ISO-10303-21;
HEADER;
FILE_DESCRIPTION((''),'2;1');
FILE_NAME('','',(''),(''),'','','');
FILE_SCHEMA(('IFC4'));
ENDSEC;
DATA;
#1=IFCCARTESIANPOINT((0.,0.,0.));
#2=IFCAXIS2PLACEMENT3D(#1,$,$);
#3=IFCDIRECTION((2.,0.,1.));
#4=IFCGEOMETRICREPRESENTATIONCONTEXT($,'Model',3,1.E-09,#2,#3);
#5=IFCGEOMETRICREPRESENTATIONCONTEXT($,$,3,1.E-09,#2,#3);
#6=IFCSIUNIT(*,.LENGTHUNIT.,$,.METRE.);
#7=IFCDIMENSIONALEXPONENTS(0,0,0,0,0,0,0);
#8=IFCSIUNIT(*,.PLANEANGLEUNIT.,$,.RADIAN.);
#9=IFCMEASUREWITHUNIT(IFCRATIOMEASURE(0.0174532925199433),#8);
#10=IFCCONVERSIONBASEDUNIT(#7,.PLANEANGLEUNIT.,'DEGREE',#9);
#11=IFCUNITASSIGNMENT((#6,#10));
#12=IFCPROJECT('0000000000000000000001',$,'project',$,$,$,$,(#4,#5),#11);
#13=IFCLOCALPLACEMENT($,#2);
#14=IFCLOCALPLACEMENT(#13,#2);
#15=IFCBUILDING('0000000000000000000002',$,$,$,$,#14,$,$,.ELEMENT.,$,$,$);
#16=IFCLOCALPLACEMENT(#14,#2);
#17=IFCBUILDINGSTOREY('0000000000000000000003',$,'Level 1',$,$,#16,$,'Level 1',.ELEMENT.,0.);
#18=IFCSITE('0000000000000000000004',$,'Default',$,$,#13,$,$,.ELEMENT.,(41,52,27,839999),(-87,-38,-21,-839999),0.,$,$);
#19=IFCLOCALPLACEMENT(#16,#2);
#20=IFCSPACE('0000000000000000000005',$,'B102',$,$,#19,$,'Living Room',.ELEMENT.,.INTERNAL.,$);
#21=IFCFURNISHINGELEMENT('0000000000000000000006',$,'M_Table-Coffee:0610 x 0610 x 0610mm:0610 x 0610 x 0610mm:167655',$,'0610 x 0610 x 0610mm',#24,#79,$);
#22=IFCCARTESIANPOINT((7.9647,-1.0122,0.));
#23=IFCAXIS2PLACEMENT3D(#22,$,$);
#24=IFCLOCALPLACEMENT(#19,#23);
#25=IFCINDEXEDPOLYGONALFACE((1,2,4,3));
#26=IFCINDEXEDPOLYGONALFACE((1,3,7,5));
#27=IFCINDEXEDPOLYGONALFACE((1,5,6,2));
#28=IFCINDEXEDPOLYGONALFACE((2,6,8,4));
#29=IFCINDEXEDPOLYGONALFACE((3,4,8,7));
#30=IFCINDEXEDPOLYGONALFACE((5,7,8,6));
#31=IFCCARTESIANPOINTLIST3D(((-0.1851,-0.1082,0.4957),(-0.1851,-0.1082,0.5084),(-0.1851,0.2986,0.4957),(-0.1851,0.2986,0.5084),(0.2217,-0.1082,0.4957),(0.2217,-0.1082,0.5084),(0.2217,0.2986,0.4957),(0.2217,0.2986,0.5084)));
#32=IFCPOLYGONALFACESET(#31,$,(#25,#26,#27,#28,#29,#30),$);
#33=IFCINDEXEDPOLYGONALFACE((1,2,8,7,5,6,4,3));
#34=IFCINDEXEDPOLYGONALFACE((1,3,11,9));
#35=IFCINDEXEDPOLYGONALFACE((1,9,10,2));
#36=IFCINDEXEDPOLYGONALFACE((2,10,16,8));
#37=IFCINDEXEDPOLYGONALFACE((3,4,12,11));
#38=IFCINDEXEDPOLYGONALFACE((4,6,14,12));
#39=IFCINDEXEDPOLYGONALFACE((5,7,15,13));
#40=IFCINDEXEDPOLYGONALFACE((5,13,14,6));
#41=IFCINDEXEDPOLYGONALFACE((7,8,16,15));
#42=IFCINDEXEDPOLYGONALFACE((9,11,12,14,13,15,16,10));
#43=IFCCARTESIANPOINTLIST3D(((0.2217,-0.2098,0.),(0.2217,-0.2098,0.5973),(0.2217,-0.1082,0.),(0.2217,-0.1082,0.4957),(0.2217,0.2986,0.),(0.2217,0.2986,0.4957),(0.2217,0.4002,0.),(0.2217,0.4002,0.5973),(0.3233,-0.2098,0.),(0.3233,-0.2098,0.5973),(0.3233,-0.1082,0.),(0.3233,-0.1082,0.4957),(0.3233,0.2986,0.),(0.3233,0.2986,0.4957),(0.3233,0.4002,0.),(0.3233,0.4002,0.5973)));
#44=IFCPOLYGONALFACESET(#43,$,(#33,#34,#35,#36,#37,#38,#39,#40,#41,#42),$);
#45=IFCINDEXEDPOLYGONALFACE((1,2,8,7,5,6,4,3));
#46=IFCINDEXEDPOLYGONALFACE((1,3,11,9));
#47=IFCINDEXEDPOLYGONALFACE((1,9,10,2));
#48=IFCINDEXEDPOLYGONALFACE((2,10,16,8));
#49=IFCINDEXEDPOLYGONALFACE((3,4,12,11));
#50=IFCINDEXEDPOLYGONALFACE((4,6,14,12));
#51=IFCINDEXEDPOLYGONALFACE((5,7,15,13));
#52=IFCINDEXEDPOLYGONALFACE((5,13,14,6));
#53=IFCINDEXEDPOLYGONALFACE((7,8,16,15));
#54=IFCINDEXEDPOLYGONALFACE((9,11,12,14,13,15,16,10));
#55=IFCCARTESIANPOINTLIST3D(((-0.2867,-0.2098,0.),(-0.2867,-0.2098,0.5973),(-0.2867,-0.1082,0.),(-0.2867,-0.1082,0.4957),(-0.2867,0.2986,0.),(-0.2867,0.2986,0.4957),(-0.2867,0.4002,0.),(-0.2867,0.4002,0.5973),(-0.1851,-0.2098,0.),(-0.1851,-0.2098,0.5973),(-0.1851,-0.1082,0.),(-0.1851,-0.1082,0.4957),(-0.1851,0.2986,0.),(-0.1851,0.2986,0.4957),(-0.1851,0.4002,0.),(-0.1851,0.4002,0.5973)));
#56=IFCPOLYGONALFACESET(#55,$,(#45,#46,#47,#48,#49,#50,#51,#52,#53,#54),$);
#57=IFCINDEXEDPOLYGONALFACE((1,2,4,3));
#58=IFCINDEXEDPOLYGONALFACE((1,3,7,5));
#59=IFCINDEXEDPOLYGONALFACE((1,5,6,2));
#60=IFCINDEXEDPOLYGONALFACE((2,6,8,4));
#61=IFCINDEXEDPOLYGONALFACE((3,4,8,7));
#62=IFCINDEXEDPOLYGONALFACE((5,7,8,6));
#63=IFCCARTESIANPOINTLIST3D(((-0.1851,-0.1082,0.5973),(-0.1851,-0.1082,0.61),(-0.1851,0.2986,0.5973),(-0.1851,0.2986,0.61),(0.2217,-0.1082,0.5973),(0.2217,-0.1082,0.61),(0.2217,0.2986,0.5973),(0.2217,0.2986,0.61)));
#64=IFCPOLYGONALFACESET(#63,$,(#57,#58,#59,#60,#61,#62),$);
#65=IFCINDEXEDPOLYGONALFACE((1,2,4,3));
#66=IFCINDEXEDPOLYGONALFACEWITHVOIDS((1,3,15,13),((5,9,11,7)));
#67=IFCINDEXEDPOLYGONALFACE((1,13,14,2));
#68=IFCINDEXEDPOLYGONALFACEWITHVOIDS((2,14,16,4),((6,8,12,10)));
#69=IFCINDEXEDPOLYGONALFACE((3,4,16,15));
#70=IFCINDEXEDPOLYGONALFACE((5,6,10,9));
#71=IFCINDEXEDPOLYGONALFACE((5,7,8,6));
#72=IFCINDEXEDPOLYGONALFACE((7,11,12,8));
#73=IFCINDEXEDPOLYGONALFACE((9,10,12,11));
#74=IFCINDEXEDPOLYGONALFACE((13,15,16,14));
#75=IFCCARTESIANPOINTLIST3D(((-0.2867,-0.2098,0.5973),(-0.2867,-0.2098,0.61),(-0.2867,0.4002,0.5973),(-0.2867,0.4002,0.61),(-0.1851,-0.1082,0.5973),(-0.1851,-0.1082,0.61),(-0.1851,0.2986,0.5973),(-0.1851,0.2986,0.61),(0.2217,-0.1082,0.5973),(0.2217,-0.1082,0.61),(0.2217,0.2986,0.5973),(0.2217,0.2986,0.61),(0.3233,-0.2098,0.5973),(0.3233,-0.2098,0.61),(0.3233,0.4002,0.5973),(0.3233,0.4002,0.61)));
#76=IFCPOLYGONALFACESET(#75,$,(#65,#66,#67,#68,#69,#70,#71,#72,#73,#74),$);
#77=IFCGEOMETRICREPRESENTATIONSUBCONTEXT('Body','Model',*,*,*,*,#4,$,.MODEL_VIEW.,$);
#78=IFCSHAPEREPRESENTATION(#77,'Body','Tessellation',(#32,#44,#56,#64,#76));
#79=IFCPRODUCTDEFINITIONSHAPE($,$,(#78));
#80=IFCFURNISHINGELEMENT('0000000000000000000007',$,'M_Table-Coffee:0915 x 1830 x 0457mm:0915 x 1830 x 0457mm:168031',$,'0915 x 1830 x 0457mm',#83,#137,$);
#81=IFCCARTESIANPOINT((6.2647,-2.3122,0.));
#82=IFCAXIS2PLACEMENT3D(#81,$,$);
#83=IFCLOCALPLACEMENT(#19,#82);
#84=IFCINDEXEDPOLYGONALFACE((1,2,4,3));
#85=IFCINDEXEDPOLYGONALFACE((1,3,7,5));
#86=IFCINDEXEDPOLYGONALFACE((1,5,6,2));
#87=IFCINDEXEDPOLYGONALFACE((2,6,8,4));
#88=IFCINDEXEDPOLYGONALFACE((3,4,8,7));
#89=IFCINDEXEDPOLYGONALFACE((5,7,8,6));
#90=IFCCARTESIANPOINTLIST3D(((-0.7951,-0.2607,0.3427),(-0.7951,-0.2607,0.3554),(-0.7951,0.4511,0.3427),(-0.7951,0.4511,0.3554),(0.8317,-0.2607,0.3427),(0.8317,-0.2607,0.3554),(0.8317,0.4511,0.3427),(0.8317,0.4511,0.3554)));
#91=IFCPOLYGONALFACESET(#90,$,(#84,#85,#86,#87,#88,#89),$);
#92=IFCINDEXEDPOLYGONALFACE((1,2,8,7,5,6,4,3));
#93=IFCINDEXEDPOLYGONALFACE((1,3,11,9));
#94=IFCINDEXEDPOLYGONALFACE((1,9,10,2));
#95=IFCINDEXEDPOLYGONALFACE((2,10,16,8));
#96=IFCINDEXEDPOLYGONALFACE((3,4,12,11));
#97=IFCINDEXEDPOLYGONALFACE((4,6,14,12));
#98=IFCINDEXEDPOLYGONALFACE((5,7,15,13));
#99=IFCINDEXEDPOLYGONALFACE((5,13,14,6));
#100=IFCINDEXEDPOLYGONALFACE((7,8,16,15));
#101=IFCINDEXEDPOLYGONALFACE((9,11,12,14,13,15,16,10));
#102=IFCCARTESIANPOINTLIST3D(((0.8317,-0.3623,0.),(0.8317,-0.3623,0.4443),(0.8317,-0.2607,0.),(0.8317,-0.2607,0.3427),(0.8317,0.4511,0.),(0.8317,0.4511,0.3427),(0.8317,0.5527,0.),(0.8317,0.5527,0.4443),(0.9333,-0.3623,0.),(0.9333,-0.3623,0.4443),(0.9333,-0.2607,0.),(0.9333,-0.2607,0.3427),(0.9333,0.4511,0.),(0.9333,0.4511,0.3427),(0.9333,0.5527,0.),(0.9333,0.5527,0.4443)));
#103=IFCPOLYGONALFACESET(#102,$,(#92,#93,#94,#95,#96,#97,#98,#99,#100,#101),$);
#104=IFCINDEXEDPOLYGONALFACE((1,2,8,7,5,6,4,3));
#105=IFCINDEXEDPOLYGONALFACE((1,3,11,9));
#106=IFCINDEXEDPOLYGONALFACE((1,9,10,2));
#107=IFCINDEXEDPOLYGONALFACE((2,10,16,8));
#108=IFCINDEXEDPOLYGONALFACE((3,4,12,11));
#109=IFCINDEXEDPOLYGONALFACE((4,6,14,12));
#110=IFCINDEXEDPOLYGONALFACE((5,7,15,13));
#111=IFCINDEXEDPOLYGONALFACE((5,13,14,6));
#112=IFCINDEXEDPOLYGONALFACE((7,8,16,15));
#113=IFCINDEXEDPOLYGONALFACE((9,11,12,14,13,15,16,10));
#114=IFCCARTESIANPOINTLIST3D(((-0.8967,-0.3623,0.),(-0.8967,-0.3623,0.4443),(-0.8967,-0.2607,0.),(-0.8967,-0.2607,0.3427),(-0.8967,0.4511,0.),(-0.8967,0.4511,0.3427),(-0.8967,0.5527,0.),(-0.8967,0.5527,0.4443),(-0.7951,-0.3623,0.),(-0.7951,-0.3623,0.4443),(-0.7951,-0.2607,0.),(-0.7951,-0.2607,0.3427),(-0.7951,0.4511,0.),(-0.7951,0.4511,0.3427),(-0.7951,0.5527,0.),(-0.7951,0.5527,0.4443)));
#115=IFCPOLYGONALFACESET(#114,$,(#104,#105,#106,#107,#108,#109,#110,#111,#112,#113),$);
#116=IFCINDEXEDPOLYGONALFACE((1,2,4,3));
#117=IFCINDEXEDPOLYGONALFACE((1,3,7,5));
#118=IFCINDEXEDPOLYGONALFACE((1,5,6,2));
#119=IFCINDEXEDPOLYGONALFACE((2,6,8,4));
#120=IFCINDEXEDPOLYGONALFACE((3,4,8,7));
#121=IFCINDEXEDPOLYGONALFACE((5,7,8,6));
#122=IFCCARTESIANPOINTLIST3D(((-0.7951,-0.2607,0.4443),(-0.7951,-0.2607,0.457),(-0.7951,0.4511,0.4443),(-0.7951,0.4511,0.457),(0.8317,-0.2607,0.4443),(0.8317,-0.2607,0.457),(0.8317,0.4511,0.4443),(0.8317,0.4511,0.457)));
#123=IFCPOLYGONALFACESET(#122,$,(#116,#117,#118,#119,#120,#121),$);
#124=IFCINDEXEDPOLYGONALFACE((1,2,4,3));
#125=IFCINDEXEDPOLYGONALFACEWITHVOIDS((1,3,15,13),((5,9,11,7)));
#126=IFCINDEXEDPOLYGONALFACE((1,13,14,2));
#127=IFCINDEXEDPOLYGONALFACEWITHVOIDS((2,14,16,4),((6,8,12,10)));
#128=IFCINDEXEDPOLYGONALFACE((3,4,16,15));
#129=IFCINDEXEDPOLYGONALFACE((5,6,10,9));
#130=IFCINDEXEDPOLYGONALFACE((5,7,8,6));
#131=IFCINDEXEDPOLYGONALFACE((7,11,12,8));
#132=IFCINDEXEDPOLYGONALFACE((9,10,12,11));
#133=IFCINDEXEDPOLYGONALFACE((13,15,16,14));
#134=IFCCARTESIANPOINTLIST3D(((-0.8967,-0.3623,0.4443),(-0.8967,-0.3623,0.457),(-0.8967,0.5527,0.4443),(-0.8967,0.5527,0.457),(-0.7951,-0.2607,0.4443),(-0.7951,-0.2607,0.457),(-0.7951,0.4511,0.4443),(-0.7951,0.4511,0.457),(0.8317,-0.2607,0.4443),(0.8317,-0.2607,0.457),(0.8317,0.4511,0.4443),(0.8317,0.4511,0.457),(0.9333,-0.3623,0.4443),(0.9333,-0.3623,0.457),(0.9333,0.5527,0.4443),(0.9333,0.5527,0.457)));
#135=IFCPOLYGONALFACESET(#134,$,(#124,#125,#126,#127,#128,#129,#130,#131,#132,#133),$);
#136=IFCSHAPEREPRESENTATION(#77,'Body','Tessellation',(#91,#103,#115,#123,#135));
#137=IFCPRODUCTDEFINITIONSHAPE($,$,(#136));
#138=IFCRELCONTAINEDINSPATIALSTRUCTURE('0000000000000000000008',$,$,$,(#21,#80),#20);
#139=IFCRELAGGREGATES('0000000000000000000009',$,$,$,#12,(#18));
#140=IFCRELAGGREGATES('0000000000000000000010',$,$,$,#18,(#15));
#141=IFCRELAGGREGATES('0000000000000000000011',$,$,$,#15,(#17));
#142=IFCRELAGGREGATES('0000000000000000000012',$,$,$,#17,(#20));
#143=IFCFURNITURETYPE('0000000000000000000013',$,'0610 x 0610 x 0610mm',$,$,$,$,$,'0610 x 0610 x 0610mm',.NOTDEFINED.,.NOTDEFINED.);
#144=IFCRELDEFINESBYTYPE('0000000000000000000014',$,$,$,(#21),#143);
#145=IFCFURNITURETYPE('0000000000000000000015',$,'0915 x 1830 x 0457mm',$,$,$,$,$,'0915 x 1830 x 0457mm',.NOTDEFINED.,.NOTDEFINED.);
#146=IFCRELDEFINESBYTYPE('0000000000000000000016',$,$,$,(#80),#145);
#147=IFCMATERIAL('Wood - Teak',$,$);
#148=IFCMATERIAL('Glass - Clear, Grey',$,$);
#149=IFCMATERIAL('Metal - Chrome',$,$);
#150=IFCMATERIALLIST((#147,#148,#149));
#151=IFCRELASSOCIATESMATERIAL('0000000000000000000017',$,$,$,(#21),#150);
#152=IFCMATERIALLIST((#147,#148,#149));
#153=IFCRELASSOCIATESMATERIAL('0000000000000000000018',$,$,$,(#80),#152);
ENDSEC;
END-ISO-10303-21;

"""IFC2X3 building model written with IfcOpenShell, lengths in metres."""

from ifc_helpers import new_model, entity, si_unit, converted_unit, direction, frame, origin, origin_2d_with_axis, place, context, subcontext, project, spatial, polyline, rectangle, outline, extrude, source, transform, mapped, material, material_list, type_object, type_shapes, element, save


model = new_model("IFC2X3")

# Units and contexts
model_context = context("Model", 3, precision=1e-09, world=origin(), true_north=direction((2.0, 0.0, 1.0)))
context_of_model = context(None, 3, precision=1e-09, world=origin(), true_north=direction((2.0, 0.0, 1.0)))
body_context = subcontext(model_context, "Body", "Model", "MODEL_VIEW")
ifc_project = project(units=[si_unit("LENGTHUNIT", "METRE"), converted_unit("PLANEANGLEUNIT", "DEGREE", entity("IfcRatioMeasure", 0.0174532925199433), si_unit("PLANEANGLEUNIT", "RADIAN"), dimensions=[0, 0, 0, 0, 0, 0, 0])], contexts=[model_context, context_of_model])

# Site, building, storey
site_placement = place(None, origin())
site = spatial("IfcSite", under=ifc_project, at=site_placement, Name="Default", CompositionType="ELEMENT", RefLatitude=(41, 52, 27, 839999), RefLongitude=(-87, -38, -21, -839999), RefElevation=0.0)
building_placement = place(site_placement, origin())
building = spatial("IfcBuilding", under=site, at=building_placement, CompositionType="ELEMENT")
storey_placement = place(building_placement, origin())
storey = spatial("IfcBuildingStorey", under=building, at=storey_placement, Name="Level 1", LongName="Level 1", CompositionType="ELEMENT", Elevation=0.0)

# Shared definitions
space_placement = place(storey_placement, origin())
space = spatial("IfcSpace", under=storey, at=space_placement, Name="B102", LongName="Living Room", CompositionType="ELEMENT", InteriorOrExteriorSpace="INTERNAL")

# Furnishing elements
ifc_material_1 = material(Name="Wood - Teak")
ifc_material_2 = material(Name="Glass - Clear, Grey")
ifc_material_3 = material(Name="Metal - Chrome")
ifc_material_list_1 = material_list([ifc_material_1, ifc_material_2, ifc_material_3])
furniture_type_1 = type_object("IfcFurnitureType", Name="0610 x 0610 x 0610mm", ElementType="0610 x 0610 x 0610mm", AssemblyPlace="NOTDEFINED")
shared_shape_1 = source(origin(), body_context, "Body", "SweptSolid", [
    extrude(rectangle(XDim=0.4068, YDim=0.4068, at=origin_2d_with_axis()), frame((0.0183, 0.0952, 0.4957), z_axis=(0.0, 0.0, 1.0), x_axis=(-1.0, 0.0, 0.0)), (0.0, 0.0, 1.0), 0.0127),
    extrude(outline(polyline([(-0.2732, -0.305), (0.324, -0.305), (0.324, 0.305), (-0.2732, 0.305), (-0.2732, 0.2034), (0.2225, 0.2034), (0.2225, -0.2034), (-0.2732, -0.2034), (-0.2732, -0.305)])), frame((0.2217, 0.0952, 0.2732), z_axis=(1.0, 0.0, 0.0), x_axis=(0.0, 0.0, 1.0)), (0.0, 0.0, 1.0), 0.1016),
    extrude(outline(polyline([(-0.305, -0.3241), (0.305, -0.3241), (0.305, 0.2733), (0.2034, 0.2733), (0.2034, -0.2224), (-0.2034, -0.2224), (-0.2034, 0.2733), (-0.305, 0.2733), (-0.305, -0.3241)])), frame((-0.2867, 0.0952, 0.2733), z_axis=(1.0, 0.0, 0.0), x_axis=(0.0, -1.0, 0.0)), (0.0, 0.0, 1.0), 0.1016),
    extrude(rectangle(XDim=0.4068, YDim=0.4068, at=origin_2d_with_axis()), frame((0.0183, 0.0952, 0.5973), z_axis=(0.0, 0.0, 1.0), x_axis=(-1.0, 0.0, 0.0)), (0.0, 0.0, 1.0), 0.0127),
    extrude(outline(polyline([(-0.305, -0.305), (0.305, -0.305), (0.305, 0.305), (-0.305, 0.305), (-0.305, -0.305)]), holes=[polyline([(-0.2034, -0.2034), (-0.2034, 0.2034), (0.2034, 0.2034), (0.2034, -0.2034), (-0.2034, -0.2034)])]), frame((0.0183, 0.0952, 0.5973), z_axis=(0.0, 0.0, 1.0), x_axis=(-1.0, 0.0, 0.0)), (0.0, 0.0, 1.0), 0.0127),
])
type_shapes(furniture_type_1, [shared_shape_1])
furnishing_1_placement = place(space_placement, frame((7.9647, -1.0122, 0.0)))
element("IfcFurnishingElement", 1, at=furnishing_1_placement, inside=space, type_object=furniture_type_1, material=ifc_material_list_1, Name="M_Table-Coffee:0610 x 0610 x 0610mm:0610 x 0610 x 0610mm:167655", ObjectType="0610 x 0610 x 0610mm", context=body_context, shape_type="MappedRepresentation", body=[
    mapped(shared_shape_1, transform((0.0, 0.0, 0.0), scale=1.0)),
])
ifc_material_list_2 = material_list([ifc_material_1, ifc_material_2, ifc_material_3])
furniture_type_2 = type_object("IfcFurnitureType", Name="0915 x 1830 x 0457mm", ElementType="0915 x 1830 x 0457mm", AssemblyPlace="NOTDEFINED")
shared_shape_2 = source(origin(), body_context, "Body", "SweptSolid", [
    extrude(rectangle(XDim=1.6268, YDim=0.7118, at=origin_2d_with_axis()), frame((0.0183, 0.0952, 0.3427), z_axis=(0.0, 0.0, 1.0), x_axis=(-1.0, 0.0, 0.0)), (0.0, 0.0, 1.0), 0.0127),
    extrude(outline(polyline([(-0.1967, -0.4575), (0.2475, -0.4575), (0.2475, 0.4575), (-0.1967, 0.4575), (-0.1967, 0.3559), (0.146, 0.3559), (0.146, -0.3559), (-0.1967, -0.3559), (-0.1967, -0.4575)])), frame((0.8317, 0.0952, 0.1967), z_axis=(1.0, 0.0, 0.0), x_axis=(0.0, 0.0, 1.0)), (0.0, 0.0, 1.0), 0.1016),
    extrude(outline(polyline([(-0.4575, -0.2476), (0.4575, -0.2476), (0.4575, 0.1968), (0.3559, 0.1968), (0.3559, -0.1459), (-0.3559, -0.1459), (-0.3559, 0.1968), (-0.4575, 0.1968), (-0.4575, -0.2476)])), frame((-0.8967, 0.0952, 0.1968), z_axis=(1.0, 0.0, 0.0), x_axis=(0.0, -1.0, 0.0)), (0.0, 0.0, 1.0), 0.1016),
    extrude(rectangle(XDim=1.6268, YDim=0.7118, at=origin_2d_with_axis()), frame((0.0183, 0.0952, 0.4443), z_axis=(0.0, 0.0, 1.0), x_axis=(-1.0, 0.0, 0.0)), (0.0, 0.0, 1.0), 0.0127),
    extrude(outline(polyline([(-0.915, -0.4575), (0.915, -0.4575), (0.915, 0.4575), (-0.915, 0.4575), (-0.915, -0.4575)]), holes=[polyline([(-0.8134, -0.3559), (-0.8134, 0.3559), (0.8134, 0.3559), (0.8134, -0.3559), (-0.8134, -0.3559)])]), frame((0.0183, 0.0952, 0.4443), z_axis=(0.0, 0.0, 1.0), x_axis=(-1.0, 0.0, 0.0)), (0.0, 0.0, 1.0), 0.0127),
])
type_shapes(furniture_type_2, [shared_shape_2])
furnishing_2_placement = place(space_placement, frame((6.2647, -2.3122, 0.0)))
element("IfcFurnishingElement", 2, at=furnishing_2_placement, inside=space, type_object=furniture_type_2, material=ifc_material_list_2, Name="M_Table-Coffee:0915 x 1830 x 0457mm:0915 x 1830 x 0457mm:168031", ObjectType="0915 x 1830 x 0457mm", context=body_context, shape_type="MappedRepresentation", body=[
    mapped(shared_shape_2, transform((0.0, 0.0, 0.0), scale=1.0)),
])

save(model, "model.ifc")
